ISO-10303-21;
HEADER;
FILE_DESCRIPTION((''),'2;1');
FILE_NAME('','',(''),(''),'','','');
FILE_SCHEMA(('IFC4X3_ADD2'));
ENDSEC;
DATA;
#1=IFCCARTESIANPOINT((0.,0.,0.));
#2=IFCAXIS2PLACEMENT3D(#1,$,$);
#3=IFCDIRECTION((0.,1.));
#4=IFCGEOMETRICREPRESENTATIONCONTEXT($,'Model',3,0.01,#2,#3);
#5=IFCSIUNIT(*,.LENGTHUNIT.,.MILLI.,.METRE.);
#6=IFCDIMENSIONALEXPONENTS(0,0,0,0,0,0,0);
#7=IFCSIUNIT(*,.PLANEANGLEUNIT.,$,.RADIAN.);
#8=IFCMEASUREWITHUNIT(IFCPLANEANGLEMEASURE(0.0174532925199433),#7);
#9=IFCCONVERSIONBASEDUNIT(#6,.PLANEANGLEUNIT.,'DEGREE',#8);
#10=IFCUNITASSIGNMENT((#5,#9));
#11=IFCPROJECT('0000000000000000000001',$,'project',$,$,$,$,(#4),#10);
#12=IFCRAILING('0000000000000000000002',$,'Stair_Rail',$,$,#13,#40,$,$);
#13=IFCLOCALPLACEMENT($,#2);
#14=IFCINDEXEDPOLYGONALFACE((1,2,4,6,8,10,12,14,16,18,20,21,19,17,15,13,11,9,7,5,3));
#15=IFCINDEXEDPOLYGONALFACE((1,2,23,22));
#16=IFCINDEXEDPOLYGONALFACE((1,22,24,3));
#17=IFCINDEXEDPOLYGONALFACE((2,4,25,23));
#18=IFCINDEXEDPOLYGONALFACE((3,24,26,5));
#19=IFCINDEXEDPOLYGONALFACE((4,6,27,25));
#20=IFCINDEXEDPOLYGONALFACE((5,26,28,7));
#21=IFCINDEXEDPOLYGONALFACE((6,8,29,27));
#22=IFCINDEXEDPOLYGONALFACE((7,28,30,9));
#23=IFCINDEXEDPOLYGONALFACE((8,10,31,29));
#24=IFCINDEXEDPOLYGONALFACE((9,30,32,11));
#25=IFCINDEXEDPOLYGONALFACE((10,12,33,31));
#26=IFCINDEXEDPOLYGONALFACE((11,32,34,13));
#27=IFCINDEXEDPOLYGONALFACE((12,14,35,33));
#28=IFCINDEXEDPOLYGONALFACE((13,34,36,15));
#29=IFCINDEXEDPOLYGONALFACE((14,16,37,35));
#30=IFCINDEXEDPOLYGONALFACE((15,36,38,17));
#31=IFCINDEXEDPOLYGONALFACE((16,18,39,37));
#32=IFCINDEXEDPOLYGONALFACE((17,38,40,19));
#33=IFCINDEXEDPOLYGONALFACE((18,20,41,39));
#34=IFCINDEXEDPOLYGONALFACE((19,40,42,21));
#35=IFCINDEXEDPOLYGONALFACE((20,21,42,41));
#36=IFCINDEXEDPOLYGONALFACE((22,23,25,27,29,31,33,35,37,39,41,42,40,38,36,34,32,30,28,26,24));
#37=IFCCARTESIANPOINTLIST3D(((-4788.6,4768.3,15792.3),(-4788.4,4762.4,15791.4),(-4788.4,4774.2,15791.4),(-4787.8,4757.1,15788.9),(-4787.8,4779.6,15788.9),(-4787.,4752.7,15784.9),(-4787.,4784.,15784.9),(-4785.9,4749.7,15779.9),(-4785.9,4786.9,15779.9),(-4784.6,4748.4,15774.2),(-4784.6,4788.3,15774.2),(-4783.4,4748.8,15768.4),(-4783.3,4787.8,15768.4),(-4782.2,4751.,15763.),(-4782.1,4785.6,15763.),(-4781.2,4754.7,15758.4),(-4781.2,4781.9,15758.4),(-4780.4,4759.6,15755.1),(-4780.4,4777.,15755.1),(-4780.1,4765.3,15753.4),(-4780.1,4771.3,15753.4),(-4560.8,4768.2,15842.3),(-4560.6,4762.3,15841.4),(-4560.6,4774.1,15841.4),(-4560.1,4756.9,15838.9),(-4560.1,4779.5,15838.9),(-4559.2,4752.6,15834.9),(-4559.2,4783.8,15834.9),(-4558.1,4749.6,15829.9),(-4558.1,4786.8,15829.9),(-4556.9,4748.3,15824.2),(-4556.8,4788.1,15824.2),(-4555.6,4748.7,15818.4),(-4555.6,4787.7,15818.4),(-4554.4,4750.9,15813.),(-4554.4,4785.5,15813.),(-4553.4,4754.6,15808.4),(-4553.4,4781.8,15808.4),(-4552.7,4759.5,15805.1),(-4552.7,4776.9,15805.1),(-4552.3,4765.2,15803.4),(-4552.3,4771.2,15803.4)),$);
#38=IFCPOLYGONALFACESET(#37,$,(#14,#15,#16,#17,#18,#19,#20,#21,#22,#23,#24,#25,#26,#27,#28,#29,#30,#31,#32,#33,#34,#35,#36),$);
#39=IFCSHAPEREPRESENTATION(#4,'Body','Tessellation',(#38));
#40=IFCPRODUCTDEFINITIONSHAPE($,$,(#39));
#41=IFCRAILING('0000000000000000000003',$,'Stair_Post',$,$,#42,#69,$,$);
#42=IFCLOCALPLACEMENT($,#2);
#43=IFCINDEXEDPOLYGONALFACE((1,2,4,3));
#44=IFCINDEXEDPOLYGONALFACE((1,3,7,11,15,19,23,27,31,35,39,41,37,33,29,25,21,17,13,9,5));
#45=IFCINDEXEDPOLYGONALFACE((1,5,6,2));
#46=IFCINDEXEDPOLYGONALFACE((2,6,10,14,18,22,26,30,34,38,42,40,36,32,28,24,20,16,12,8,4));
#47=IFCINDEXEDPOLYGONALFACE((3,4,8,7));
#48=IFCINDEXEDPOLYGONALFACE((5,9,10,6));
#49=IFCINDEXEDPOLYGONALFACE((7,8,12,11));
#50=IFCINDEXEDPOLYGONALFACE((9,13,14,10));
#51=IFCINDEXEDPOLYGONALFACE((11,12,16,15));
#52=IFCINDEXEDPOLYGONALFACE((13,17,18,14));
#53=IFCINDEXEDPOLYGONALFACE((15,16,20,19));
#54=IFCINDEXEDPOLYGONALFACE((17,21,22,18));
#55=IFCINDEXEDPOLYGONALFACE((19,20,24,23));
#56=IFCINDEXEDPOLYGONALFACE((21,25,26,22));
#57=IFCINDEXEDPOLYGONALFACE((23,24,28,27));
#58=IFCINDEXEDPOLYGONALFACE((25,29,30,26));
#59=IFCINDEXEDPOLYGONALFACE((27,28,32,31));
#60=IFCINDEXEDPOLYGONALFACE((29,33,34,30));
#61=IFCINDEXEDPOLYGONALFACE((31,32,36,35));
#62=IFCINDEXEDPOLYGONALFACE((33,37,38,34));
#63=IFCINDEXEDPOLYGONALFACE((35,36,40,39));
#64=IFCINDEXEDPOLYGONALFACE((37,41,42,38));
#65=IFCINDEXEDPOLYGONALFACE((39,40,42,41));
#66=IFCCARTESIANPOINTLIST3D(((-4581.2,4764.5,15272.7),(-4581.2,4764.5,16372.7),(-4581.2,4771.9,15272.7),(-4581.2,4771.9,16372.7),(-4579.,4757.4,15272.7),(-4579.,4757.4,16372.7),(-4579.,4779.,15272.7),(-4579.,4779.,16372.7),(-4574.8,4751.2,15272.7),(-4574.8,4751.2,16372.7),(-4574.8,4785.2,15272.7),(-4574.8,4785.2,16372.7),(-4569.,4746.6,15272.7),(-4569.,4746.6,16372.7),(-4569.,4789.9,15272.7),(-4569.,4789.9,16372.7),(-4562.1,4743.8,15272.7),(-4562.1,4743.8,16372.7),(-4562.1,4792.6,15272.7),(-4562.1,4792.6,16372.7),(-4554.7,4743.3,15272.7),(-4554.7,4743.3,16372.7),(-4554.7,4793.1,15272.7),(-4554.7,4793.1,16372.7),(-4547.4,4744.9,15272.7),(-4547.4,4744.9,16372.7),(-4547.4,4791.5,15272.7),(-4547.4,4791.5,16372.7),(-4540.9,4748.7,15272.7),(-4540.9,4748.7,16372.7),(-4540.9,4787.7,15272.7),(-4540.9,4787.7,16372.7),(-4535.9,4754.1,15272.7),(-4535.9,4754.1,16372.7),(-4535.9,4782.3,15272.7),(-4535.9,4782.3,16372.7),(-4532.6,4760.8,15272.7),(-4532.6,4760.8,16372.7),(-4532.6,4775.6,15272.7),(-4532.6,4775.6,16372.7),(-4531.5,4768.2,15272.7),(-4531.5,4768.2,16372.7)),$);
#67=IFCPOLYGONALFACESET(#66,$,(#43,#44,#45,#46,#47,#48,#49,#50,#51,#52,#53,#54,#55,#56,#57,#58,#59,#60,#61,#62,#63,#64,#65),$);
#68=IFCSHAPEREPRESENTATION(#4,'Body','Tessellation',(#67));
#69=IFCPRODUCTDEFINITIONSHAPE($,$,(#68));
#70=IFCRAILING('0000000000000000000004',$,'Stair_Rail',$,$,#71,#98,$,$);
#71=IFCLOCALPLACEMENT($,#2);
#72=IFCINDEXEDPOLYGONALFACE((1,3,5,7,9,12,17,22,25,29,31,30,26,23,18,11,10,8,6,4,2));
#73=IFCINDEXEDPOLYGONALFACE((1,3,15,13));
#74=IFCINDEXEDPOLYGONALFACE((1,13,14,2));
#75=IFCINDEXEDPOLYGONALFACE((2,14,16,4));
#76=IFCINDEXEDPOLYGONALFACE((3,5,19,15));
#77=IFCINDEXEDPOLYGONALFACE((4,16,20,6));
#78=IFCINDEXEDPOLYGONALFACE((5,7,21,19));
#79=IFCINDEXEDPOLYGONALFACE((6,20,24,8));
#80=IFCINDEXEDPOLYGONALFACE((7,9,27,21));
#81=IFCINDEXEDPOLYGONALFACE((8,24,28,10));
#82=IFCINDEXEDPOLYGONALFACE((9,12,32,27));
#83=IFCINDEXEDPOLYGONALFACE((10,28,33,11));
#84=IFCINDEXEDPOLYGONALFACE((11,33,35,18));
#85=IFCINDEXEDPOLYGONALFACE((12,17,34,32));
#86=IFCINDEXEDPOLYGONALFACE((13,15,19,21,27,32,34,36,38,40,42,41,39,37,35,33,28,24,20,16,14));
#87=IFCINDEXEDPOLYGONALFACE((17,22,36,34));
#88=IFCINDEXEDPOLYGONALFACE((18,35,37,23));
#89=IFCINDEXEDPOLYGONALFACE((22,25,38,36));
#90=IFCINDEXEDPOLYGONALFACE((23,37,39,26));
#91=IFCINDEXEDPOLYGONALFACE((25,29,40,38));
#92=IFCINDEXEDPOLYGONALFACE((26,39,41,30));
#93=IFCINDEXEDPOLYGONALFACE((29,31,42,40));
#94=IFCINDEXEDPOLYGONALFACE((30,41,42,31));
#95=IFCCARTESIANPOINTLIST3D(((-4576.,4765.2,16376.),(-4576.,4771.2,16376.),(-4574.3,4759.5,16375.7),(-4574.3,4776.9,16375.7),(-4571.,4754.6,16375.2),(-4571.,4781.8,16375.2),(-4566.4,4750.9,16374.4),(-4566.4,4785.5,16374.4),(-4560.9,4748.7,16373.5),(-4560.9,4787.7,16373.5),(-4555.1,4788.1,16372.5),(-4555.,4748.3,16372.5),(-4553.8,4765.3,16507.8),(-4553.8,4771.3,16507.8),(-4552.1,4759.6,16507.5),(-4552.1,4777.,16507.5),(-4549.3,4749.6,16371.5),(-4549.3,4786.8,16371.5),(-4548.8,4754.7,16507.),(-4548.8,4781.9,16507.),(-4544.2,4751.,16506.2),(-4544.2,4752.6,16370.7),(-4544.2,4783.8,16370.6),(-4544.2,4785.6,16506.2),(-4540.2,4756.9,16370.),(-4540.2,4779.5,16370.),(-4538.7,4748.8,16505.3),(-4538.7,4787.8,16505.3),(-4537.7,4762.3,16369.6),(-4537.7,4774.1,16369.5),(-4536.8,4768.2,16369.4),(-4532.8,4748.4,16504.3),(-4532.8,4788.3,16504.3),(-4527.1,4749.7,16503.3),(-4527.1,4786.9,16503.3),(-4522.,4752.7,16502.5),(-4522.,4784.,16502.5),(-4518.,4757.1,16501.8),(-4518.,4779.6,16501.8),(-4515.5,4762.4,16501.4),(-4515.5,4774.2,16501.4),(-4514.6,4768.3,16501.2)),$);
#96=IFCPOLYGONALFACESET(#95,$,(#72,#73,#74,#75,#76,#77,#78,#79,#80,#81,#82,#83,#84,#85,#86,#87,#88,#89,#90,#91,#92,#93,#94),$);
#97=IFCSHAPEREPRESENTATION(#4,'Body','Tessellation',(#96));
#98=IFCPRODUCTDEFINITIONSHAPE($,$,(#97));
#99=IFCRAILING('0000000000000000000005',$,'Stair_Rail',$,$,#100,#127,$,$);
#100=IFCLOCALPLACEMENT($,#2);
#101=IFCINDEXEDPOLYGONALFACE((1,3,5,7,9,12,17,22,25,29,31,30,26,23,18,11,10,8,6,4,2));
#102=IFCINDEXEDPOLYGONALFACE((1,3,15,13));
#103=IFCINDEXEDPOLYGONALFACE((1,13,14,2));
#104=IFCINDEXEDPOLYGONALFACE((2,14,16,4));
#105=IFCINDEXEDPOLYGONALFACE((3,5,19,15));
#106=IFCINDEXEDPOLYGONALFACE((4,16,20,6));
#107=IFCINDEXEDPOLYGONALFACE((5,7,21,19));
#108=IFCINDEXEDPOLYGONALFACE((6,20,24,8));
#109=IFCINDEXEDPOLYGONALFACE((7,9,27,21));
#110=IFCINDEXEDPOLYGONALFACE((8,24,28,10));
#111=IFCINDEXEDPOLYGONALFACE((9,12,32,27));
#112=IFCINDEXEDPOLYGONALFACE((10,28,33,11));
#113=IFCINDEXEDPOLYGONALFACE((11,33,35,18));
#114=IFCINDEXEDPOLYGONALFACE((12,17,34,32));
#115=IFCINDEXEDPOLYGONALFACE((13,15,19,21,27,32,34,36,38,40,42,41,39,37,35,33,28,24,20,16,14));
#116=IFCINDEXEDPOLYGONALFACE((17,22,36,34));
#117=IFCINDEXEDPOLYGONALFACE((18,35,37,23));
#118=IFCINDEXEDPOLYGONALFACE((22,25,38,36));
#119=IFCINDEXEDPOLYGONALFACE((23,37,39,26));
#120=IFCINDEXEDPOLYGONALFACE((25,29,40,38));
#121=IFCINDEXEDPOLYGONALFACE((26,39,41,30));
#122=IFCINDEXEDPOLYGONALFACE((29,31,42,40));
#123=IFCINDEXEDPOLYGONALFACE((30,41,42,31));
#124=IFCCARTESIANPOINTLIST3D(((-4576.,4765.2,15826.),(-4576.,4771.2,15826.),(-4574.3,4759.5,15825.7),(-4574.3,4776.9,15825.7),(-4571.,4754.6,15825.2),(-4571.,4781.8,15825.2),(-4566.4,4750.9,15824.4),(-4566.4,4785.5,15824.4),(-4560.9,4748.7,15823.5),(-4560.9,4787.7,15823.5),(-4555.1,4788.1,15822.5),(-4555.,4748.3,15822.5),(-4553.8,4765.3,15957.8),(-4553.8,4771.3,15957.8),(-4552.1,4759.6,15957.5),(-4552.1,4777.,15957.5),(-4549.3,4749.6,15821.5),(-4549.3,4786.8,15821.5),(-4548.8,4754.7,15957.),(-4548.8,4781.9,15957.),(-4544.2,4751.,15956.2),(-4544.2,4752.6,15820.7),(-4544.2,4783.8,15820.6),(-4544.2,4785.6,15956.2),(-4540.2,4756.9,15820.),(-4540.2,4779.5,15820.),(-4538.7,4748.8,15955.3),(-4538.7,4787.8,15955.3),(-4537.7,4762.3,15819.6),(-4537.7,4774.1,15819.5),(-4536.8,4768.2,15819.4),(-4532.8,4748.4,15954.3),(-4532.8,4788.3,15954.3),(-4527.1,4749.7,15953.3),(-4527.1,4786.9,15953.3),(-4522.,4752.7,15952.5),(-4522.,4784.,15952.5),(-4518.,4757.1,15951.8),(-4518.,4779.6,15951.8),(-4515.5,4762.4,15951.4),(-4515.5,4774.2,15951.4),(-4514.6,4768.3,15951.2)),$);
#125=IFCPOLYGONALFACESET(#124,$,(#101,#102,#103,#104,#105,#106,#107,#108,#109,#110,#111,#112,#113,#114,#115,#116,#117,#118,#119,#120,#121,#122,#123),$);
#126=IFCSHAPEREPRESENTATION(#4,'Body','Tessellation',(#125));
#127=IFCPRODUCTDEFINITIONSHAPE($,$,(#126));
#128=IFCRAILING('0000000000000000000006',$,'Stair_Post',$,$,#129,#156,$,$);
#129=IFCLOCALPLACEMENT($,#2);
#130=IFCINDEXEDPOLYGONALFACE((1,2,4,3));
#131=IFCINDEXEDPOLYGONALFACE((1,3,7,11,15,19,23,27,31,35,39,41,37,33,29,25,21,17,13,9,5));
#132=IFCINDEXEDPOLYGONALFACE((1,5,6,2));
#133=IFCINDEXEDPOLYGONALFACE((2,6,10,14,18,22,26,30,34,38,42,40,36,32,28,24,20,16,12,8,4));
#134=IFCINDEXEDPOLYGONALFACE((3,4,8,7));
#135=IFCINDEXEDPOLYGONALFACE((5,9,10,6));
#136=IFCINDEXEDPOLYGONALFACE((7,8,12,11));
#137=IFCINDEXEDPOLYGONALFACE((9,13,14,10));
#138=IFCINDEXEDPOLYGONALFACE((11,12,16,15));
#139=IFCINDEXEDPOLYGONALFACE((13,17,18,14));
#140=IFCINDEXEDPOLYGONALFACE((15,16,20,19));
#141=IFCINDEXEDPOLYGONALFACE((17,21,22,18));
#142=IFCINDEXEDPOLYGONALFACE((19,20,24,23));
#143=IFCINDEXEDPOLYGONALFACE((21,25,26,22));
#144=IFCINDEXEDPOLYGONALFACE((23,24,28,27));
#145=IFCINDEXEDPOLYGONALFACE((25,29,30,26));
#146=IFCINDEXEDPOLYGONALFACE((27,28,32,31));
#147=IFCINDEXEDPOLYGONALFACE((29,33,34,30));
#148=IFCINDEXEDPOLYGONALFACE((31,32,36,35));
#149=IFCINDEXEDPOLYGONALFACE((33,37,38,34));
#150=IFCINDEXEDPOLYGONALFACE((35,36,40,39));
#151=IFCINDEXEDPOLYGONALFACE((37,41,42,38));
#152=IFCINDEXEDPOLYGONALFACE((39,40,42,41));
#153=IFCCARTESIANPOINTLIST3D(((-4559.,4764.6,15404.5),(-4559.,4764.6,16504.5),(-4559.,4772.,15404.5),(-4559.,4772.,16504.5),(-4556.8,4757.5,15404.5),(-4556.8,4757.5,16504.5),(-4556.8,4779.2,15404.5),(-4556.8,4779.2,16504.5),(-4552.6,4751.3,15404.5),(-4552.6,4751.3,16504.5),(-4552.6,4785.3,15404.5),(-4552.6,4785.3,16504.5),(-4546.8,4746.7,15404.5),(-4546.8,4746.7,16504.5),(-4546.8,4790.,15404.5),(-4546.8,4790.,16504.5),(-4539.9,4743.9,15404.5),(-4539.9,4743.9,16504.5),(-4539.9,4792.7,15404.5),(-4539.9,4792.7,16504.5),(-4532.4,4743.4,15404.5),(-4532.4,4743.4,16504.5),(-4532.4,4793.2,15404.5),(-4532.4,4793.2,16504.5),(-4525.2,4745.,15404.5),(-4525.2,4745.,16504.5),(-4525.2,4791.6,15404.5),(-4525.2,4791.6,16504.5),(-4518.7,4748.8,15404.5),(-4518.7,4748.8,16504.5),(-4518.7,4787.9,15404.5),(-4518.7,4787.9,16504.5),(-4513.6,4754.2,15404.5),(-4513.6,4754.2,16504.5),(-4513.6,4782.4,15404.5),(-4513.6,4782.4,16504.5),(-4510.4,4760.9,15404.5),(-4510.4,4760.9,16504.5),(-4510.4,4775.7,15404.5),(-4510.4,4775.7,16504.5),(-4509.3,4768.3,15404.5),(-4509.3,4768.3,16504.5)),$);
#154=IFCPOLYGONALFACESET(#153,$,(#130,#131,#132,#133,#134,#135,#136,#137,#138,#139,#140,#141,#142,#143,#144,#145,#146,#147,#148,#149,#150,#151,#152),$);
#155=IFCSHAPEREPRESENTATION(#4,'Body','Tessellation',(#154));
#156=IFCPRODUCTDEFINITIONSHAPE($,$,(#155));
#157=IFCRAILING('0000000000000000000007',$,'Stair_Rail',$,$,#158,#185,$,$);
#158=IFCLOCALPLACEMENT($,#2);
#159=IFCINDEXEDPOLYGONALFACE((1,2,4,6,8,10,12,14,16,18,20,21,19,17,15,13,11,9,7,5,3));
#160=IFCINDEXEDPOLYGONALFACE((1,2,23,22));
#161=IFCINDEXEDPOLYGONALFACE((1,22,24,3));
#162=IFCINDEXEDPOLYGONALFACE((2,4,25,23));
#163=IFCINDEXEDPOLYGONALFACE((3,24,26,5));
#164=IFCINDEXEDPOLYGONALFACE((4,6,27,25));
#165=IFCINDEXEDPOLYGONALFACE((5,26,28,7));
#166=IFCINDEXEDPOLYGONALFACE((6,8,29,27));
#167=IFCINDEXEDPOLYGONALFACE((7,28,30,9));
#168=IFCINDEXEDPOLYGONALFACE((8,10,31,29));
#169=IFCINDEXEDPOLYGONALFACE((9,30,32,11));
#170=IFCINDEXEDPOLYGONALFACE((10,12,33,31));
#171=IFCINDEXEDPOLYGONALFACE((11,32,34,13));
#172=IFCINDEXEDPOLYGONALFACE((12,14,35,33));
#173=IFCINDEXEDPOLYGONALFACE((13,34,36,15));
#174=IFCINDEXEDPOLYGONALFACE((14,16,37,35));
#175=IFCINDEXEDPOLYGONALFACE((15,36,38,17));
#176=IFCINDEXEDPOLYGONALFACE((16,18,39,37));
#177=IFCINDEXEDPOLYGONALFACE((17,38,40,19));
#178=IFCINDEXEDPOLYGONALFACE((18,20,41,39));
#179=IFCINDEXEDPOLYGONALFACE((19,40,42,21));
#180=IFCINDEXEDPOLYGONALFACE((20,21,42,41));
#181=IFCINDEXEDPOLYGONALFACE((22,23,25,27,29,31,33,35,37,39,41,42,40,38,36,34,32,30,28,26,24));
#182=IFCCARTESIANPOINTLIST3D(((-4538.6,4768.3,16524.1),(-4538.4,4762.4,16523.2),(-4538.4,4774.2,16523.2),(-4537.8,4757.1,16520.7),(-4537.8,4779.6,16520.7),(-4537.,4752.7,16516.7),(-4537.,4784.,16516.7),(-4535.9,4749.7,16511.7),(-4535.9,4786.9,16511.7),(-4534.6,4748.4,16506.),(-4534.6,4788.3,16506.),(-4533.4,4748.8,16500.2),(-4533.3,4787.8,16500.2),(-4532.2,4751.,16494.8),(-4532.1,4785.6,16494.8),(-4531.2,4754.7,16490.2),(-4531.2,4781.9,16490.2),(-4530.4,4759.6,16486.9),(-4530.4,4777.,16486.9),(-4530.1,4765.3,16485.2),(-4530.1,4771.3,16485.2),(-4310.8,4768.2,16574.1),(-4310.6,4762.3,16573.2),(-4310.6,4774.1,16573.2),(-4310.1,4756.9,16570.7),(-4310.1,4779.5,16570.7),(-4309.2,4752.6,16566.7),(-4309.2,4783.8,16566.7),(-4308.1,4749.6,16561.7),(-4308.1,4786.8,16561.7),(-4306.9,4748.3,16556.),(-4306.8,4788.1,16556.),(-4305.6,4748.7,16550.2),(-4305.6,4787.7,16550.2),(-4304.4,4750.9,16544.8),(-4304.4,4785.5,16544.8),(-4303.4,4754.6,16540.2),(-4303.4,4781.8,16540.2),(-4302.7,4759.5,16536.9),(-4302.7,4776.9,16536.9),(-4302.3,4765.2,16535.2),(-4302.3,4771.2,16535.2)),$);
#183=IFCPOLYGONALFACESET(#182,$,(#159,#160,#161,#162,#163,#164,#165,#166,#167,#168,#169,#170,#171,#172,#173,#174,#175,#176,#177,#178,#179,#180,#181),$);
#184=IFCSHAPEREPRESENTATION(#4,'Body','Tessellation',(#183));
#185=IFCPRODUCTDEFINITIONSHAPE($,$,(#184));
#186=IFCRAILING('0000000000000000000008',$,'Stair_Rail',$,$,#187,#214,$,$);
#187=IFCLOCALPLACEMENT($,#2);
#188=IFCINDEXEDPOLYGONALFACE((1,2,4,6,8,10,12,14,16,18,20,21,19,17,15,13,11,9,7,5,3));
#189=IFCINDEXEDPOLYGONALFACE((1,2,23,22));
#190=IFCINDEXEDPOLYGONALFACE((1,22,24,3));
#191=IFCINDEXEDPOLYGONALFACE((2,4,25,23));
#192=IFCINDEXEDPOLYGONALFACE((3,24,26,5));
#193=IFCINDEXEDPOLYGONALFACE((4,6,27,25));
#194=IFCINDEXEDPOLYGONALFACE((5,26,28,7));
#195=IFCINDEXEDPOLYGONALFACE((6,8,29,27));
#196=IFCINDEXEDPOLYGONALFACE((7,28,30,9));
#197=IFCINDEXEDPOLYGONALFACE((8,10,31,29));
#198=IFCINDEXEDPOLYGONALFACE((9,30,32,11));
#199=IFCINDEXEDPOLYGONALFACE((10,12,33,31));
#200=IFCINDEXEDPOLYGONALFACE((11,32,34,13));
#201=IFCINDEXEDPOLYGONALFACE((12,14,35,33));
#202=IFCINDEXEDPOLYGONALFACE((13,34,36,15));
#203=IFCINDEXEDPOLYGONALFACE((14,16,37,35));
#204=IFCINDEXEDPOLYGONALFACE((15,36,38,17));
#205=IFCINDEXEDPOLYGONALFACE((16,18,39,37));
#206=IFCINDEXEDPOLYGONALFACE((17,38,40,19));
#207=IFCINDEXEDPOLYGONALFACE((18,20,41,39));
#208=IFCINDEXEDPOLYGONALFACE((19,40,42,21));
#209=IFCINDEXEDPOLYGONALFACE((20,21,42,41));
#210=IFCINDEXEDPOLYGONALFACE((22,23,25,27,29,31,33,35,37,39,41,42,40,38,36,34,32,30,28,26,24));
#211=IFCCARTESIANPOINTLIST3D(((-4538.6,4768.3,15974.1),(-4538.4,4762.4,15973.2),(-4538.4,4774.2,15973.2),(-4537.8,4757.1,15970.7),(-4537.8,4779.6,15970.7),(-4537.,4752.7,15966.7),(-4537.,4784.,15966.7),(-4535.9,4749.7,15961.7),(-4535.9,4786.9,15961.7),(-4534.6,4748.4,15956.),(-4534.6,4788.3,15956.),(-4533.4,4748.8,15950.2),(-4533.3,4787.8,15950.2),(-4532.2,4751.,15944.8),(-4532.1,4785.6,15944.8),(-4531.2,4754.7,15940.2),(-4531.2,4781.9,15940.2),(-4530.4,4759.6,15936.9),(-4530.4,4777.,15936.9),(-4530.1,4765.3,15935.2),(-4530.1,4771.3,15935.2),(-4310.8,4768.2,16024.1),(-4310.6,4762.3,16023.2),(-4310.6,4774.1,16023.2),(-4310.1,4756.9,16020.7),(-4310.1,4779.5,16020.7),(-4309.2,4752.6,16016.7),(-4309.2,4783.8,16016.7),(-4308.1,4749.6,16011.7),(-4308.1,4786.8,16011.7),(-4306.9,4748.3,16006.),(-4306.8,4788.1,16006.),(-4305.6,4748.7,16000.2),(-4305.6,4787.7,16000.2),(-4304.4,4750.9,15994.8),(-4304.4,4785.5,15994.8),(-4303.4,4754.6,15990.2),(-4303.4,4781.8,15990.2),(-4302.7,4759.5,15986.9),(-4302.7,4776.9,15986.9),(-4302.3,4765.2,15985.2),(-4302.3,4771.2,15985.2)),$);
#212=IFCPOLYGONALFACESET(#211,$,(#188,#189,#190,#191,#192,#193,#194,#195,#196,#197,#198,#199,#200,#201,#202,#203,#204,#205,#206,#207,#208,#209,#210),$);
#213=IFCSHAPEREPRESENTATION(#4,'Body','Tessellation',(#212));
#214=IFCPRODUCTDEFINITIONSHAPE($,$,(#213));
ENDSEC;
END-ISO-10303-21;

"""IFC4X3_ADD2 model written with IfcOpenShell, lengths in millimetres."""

from ifc_helpers import new_model, entity, si_unit, converted_unit, direction, frame, origin, context, project, circle, extrude, element, save


model = new_model("IFC4X3_ADD2")

# Units and contexts
model_context = context("Model", 3, precision=0.01, world=origin(), true_north=direction((0.0, 1.0)))
ifc_project = project(units=[si_unit("LENGTHUNIT", "METRE", prefix="MILLI"), converted_unit("PLANEANGLEUNIT", "DEGREE", entity("IfcPlaneAngleMeasure", 0.0174532925199433), si_unit("PLANEANGLEUNIT", "RADIAN"), dimensions=[0, 0, 0, 0, 0, 0, 0])], contexts=[model_context])

# Railings
element("IfcRailing", 1, Name="Stair_Rail", context=model_context, shape_type="SweptSolid", body=[
    entity("IfcSweptDiskSolid", entity("IfcPolyline", [entity("IfcCartesianPoint", [-4784.3, 4768.3, 15772.7]), entity("IfcCartesianPoint", [-4556.5, 4768.2, 15822.7])]), 20.0),
])
element("IfcRailing", 2, Name="Stair_Post", context=model_context, shape_type="SweptSolid", body=[
    extrude(circle(Radius=25.0), frame((-4556.5, 4768.2, 15272.7)), (0.0, 0.0, 1.0), 1100.0),
])
element("IfcRailing", 3, Name="Stair_Rail", context=model_context, shape_type="SweptSolid", body=[
    entity("IfcSweptDiskSolid", entity("IfcPolyline", [entity("IfcCartesianPoint", [-4556.5, 4768.2, 16372.7]), entity("IfcCartesianPoint", [-4534.3, 4768.3, 16504.5])]), 20.0),
])
element("IfcRailing", 4, Name="Stair_Rail", context=model_context, shape_type="SweptSolid", body=[
    entity("IfcSweptDiskSolid", entity("IfcPolyline", [entity("IfcCartesianPoint", [-4556.5, 4768.2, 15822.7]), entity("IfcCartesianPoint", [-4534.3, 4768.3, 15954.5])]), 20.0),
])
element("IfcRailing", 5, Name="Stair_Post", context=model_context, shape_type="SweptSolid", body=[
    extrude(circle(Radius=25.0), frame((-4534.3, 4768.3, 15404.5)), (0.0, 0.0, 1.0), 1100.0),
])
element("IfcRailing", 6, Name="Stair_Rail", context=model_context, shape_type="SweptSolid", body=[
    entity("IfcSweptDiskSolid", entity("IfcPolyline", [entity("IfcCartesianPoint", [-4534.3, 4768.3, 16504.5]), entity("IfcCartesianPoint", [-4306.5, 4768.2, 16554.5])]), 20.0),
])
element("IfcRailing", 7, Name="Stair_Rail", context=model_context, shape_type="SweptSolid", body=[
    entity("IfcSweptDiskSolid", entity("IfcPolyline", [entity("IfcCartesianPoint", [-4534.3, 4768.3, 15954.5]), entity("IfcCartesianPoint", [-4306.5, 4768.2, 16004.5])]), 20.0),
])

save(model, "model.ifc")
